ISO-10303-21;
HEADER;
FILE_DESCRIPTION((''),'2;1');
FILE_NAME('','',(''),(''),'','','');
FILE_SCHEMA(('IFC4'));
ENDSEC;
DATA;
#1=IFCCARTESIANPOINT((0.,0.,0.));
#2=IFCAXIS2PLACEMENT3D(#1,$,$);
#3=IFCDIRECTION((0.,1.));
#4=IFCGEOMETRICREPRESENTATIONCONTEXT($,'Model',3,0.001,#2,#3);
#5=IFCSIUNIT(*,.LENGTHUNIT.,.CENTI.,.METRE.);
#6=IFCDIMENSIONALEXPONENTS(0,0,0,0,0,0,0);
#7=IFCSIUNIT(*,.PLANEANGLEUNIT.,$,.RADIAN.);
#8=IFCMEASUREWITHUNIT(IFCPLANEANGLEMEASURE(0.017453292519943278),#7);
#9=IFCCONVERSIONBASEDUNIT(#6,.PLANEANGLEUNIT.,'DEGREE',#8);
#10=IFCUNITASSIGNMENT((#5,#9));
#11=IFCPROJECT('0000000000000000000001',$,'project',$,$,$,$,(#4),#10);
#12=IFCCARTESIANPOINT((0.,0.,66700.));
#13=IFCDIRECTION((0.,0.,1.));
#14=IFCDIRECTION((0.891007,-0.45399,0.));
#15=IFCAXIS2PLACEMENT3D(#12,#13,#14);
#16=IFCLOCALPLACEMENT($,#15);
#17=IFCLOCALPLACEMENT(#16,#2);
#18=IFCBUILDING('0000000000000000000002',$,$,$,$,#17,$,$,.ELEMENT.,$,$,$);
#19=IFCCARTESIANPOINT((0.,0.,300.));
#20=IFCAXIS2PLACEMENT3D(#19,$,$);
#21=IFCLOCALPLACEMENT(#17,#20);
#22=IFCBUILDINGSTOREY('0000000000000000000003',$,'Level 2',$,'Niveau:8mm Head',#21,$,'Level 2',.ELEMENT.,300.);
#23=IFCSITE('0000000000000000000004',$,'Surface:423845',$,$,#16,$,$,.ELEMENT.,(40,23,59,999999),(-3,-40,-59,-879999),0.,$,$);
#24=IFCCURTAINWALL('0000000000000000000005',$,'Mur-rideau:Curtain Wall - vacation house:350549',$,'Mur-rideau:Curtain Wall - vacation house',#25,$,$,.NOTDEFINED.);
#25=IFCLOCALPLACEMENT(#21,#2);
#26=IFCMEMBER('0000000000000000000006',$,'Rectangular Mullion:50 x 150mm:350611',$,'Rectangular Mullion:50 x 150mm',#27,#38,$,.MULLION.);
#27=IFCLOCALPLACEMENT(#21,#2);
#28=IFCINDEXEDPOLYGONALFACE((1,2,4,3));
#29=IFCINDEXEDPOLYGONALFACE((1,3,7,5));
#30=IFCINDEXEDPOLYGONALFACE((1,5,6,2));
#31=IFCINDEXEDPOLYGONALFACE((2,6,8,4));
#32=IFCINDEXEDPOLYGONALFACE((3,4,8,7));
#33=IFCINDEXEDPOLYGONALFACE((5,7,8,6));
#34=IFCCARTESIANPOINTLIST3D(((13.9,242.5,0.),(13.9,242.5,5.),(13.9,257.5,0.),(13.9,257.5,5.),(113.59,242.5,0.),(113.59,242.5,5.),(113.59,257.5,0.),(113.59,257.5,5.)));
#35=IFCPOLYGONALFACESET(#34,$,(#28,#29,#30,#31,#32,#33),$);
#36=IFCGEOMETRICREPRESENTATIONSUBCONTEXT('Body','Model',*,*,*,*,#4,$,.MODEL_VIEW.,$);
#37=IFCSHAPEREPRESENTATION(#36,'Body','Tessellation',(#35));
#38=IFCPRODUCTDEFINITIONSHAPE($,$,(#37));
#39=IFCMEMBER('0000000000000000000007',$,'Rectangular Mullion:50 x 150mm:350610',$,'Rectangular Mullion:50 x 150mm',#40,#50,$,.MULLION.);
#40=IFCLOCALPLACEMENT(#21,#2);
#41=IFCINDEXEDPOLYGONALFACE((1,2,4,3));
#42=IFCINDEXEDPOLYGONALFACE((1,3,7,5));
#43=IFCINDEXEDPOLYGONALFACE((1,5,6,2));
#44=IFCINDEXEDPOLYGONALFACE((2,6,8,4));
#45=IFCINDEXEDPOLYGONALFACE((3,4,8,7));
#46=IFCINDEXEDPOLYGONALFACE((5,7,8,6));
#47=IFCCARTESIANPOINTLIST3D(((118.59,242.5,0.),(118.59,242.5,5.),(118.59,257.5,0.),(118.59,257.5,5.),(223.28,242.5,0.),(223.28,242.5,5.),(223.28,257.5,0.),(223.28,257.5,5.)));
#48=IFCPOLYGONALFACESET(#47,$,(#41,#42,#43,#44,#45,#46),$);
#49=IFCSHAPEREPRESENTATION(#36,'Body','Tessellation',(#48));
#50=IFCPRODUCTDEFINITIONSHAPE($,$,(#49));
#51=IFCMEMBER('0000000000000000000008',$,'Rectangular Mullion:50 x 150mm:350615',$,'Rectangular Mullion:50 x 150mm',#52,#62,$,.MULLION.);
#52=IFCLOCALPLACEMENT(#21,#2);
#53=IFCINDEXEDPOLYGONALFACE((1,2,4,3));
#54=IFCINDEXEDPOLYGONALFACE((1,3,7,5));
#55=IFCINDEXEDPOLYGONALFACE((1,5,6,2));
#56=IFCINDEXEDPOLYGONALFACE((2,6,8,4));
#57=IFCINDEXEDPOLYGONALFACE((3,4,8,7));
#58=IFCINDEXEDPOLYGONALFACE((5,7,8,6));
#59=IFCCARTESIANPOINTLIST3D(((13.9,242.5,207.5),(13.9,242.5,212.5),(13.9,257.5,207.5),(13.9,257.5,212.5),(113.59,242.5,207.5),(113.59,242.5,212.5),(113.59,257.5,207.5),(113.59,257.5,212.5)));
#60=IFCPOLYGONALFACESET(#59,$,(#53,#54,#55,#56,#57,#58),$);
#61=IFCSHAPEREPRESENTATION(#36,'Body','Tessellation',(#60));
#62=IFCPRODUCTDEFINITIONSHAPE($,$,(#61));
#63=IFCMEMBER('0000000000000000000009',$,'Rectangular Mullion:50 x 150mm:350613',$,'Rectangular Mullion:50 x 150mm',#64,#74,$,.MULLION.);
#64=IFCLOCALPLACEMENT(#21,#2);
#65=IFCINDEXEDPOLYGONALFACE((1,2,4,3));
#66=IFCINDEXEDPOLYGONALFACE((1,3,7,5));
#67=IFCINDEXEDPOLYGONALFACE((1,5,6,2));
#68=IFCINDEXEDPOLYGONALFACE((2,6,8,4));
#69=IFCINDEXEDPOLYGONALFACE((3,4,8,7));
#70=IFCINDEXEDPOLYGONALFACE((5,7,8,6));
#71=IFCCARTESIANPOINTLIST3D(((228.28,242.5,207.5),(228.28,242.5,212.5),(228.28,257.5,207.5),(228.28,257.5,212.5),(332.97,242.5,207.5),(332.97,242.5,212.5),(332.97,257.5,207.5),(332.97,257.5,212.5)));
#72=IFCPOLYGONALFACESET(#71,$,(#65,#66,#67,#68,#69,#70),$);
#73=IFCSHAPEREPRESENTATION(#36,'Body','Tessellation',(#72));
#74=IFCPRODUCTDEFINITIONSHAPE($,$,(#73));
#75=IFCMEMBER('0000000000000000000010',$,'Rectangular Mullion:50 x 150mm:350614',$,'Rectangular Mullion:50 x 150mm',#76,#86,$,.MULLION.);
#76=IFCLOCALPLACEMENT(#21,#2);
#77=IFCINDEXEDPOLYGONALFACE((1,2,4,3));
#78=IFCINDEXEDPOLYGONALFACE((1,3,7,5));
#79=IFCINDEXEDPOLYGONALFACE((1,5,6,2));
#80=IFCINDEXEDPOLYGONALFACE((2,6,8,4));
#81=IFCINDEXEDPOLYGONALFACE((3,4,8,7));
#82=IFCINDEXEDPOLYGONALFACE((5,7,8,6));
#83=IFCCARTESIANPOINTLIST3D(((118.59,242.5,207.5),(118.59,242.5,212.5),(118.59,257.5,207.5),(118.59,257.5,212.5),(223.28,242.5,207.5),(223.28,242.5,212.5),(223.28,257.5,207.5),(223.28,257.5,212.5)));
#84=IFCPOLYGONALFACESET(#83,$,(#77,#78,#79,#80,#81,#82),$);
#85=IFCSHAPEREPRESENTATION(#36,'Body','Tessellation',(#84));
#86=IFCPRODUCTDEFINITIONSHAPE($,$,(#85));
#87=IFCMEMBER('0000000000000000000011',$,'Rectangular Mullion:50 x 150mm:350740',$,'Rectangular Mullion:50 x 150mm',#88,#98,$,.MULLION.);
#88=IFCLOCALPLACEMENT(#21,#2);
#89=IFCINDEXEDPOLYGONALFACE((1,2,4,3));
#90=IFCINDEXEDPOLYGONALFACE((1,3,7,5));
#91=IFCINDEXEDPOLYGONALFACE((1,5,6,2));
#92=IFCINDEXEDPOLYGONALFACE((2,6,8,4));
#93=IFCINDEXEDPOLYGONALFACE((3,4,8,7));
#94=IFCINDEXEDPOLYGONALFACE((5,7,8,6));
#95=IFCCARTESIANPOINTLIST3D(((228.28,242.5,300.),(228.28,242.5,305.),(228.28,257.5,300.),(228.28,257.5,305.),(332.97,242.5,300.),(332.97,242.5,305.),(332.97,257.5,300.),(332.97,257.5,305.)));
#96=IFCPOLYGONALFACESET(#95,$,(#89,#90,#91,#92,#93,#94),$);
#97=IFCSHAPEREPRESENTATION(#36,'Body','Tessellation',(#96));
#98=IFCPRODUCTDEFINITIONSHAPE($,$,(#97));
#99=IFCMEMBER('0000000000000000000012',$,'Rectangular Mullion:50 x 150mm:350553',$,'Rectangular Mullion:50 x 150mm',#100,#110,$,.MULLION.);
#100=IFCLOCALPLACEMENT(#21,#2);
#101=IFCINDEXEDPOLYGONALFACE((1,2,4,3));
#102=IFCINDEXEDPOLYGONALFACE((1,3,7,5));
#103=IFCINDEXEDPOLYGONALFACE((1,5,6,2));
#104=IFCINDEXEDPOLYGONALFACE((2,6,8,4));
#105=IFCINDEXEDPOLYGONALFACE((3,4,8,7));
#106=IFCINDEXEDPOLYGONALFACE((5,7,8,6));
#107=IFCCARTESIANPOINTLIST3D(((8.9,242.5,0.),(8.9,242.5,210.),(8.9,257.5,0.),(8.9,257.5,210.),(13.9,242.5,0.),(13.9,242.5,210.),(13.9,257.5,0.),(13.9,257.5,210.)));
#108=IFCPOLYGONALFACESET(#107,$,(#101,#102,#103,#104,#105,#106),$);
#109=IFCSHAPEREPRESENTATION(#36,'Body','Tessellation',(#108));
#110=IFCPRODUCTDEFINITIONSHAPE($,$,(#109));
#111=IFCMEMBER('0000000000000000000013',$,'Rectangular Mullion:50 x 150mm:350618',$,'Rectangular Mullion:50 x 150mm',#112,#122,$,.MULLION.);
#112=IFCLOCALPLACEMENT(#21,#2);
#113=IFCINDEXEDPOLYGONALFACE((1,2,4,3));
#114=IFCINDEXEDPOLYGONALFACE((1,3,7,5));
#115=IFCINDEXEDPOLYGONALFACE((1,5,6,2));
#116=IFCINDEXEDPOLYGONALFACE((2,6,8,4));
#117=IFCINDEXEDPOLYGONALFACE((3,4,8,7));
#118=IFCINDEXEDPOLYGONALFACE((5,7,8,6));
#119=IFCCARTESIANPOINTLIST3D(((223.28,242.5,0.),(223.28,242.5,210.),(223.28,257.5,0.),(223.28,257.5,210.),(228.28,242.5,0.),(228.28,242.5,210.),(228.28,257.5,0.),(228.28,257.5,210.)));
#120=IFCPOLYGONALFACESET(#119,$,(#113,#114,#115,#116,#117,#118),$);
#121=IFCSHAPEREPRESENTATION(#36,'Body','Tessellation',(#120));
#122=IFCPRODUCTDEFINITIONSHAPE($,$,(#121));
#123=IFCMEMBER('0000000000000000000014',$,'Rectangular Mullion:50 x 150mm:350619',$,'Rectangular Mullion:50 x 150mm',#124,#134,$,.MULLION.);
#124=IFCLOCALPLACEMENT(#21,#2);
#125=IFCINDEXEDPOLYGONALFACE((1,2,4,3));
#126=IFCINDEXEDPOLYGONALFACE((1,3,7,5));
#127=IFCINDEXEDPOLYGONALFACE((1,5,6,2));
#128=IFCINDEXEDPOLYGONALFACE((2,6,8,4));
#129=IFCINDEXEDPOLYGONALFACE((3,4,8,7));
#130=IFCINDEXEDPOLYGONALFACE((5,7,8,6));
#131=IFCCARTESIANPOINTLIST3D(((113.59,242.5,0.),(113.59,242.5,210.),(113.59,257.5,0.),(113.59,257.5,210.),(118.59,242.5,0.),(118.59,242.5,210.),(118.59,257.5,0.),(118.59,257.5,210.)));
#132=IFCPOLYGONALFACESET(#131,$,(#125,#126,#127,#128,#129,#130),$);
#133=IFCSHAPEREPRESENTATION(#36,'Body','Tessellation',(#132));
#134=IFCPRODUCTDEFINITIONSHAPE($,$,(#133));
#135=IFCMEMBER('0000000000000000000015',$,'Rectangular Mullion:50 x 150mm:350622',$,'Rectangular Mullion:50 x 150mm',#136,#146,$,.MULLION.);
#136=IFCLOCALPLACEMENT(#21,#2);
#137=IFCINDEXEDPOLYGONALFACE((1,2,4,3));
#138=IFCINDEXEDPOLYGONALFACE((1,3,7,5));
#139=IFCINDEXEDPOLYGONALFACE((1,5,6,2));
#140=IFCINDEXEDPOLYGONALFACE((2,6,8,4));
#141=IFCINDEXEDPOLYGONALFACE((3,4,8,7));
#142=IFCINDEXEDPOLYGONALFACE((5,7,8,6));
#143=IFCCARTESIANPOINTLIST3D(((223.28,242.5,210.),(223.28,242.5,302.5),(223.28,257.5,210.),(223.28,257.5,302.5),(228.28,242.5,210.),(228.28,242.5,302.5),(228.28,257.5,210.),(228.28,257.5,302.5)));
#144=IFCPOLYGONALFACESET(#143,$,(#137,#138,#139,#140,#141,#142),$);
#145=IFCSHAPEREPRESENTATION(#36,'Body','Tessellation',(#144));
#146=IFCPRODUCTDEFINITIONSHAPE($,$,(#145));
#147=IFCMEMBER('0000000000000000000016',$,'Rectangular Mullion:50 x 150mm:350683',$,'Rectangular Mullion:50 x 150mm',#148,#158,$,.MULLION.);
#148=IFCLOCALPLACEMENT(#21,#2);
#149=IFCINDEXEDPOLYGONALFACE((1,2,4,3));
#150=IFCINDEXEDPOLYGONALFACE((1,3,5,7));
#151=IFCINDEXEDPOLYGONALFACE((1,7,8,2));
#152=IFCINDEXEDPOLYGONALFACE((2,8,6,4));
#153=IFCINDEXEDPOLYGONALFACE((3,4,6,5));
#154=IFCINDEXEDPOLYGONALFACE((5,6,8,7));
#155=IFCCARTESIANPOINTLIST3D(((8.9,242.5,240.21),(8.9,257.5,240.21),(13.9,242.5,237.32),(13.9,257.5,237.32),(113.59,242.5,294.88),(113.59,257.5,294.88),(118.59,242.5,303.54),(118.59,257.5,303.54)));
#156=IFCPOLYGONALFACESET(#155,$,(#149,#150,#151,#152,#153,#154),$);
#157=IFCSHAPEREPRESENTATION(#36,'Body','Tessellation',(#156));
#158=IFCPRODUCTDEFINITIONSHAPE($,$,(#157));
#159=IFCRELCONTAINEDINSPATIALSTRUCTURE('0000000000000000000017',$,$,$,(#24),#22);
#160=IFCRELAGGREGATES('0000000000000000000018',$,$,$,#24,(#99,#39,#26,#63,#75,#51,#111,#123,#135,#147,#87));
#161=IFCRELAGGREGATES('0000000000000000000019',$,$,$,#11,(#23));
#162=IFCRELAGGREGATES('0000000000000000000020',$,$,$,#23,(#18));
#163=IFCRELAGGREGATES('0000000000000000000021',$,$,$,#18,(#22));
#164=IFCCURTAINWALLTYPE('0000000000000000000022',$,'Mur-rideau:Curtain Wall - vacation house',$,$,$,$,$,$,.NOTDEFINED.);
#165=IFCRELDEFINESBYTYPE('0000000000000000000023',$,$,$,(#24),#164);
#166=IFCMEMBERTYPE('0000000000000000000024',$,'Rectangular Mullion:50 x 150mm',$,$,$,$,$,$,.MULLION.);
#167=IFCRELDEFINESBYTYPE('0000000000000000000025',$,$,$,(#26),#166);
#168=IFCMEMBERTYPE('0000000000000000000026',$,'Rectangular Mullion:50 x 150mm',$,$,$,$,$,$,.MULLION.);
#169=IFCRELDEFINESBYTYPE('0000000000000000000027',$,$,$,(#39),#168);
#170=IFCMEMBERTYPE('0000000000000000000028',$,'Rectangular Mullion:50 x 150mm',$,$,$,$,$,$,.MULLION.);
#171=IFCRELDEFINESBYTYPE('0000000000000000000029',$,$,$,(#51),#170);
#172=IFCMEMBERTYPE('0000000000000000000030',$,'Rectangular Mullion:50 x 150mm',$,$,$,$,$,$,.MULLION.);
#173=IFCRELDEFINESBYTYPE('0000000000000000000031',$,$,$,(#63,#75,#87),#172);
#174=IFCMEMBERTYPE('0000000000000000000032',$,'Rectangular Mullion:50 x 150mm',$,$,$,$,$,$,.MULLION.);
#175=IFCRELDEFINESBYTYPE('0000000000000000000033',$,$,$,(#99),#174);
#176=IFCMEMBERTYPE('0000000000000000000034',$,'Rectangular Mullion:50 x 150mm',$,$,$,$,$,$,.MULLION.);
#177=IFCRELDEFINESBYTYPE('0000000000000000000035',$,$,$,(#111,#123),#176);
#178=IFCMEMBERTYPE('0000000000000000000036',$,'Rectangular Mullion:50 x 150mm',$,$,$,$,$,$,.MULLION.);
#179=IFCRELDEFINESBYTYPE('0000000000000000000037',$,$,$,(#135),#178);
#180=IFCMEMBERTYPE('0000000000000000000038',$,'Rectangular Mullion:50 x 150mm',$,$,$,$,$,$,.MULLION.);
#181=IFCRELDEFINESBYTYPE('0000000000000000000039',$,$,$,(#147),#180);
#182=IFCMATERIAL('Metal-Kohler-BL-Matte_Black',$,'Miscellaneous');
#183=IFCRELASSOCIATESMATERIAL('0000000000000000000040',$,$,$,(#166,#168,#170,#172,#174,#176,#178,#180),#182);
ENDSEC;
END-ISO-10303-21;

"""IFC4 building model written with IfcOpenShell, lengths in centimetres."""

from ifc_helpers import new_model, entity, si_unit, converted_unit, direction, frame, origin, origin_2d_with_axis, place, context, subcontext, project, spatial, polyline, rectangle, outline, extrude, source, transform, mapped, material, material_profile, profile_set, type_object, type_shapes, element, aggregate, save


model = new_model("IFC4")

# Units and contexts
model_context = context("Model", 3, precision=0.001, world=origin(), true_north=direction((0.0, 1.0)))
body_context = subcontext(model_context, "Body", "Model", "MODEL_VIEW")
ifc_project = project(units=[si_unit("LENGTHUNIT", "METRE", prefix="CENTI"), converted_unit("PLANEANGLEUNIT", "DEGREE", entity("IfcPlaneAngleMeasure", 0.017453292519943278), si_unit("PLANEANGLEUNIT", "RADIAN"), dimensions=[0, 0, 0, 0, 0, 0, 0])], contexts=[model_context])

# Site, building, storey
site_placement = place(None, frame((0.0, 0.0, 66700.0), z_axis=(0.0, 0.0, 1.0), x_axis=(0.891007, -0.45399, 0.0)))
site = spatial("IfcSite", under=ifc_project, at=site_placement, Name="Surface:423845", CompositionType="ELEMENT", RefLatitude=(40, 23, 59, 999999), RefLongitude=(-3, -40, -59, -879999), RefElevation=0.0)
building_placement = place(site_placement, origin())
building = spatial("IfcBuilding", under=site, at=building_placement, CompositionType="ELEMENT")
storey_placement = place(building_placement, frame((0.0, 0.0, 300.0)))
storey = spatial("IfcBuildingStorey", under=building, at=storey_placement, Name="Level 2", ObjectType="Niveau:8mm Head", LongName="Level 2", CompositionType="ELEMENT", Elevation=300.0)

# Curtain wall, members
curtain_wall_type = type_object("IfcCurtainWallType", Name="Mur-rideau:Curtain Wall - vacation house", PredefinedType="NOTDEFINED")
curtain_wall_placement = place(storey_placement, frame((0.0, 0.0, -300.0)))
curtain_wall = element("IfcCurtainWall", 1, at=curtain_wall_placement, inside=storey, type_object=curtain_wall_type, Name="Mur-rideau:Curtain Wall - vacation house:350549", ObjectType="Mur-rideau:Curtain Wall - vacation house", PredefinedType="NOTDEFINED")
ifc_material_1 = material(Name="Metal-Kohler-BL-Matte_Black", Category="Miscellaneous")
ifc_material_profile = material_profile(ifc_material_1, rectangle(XDim=5.0, YDim=15.0, at=origin_2d_with_axis()), Name="50 x 150mm")
ifc_profile_set = profile_set([ifc_material_profile], Name="50 x 150mm")
member_type_1 = type_object("IfcMemberType", Name="Rectangular Mullion:50 x 150mm", PredefinedType="MULLION", material=ifc_profile_set)
shared_shape_1 = source(origin(), body_context, "Body", "SweptSolid", [
    extrude(rectangle(XDim=5.0, YDim=15.0, at=origin_2d_with_axis()), frame((-2.5, 0.0, -99.69), z_axis=(0.0, 0.0, 1.0), x_axis=(-1.0, 0.0, 0.0)), (0.0, 0.0, 1.0), 99.69),
])
type_shapes(member_type_1, [shared_shape_1])
member_1_placement = place(curtain_wall_placement, frame((113.59, 250.0, 300.0), z_axis=(1.0, 0.0, 0.0), x_axis=(0.0, 0.0, -1.0)))
member_1 = element("IfcMember", 2, at=member_1_placement, type_object=member_type_1, Name="Rectangular Mullion:50 x 150mm:350611", ObjectType="Rectangular Mullion:50 x 150mm", PredefinedType="MULLION", context=body_context, shape_type="MappedRepresentation", body=[
    mapped(shared_shape_1, transform((0.0, 0.0, 0.0), scale=1.0)),
])
member_type_2 = type_object("IfcMemberType", Name="Rectangular Mullion:50 x 150mm", PredefinedType="MULLION", material=ifc_profile_set)
shared_shape_2 = source(origin(), body_context, "Body", "SweptSolid", [
    extrude(rectangle(XDim=5.0, YDim=15.0, at=origin_2d_with_axis()), frame((-2.5, 0.0, -104.69), z_axis=(0.0, 0.0, 1.0), x_axis=(-1.0, 0.0, 0.0)), (0.0, 0.0, 1.0), 104.69),
])
type_shapes(member_type_2, [shared_shape_2])
member_2_placement = place(curtain_wall_placement, frame((223.28, 250.0, 300.0), z_axis=(1.0, 0.0, 0.0), x_axis=(0.0, 0.0, -1.0)))
member_2 = element("IfcMember", 3, at=member_2_placement, type_object=member_type_2, Name="Rectangular Mullion:50 x 150mm:350610", ObjectType="Rectangular Mullion:50 x 150mm", PredefinedType="MULLION", context=body_context, shape_type="MappedRepresentation", body=[
    mapped(shared_shape_2, transform((0.0, 0.0, 0.0), scale=1.0)),
])
member_type_3 = type_object("IfcMemberType", Name="Rectangular Mullion:50 x 150mm", PredefinedType="MULLION", material=ifc_profile_set)
shared_shape_3 = source(origin(), body_context, "Body", "SweptSolid", [
    extrude(rectangle(XDim=5.0, YDim=15.0, at=origin_2d_with_axis()), frame((0.0, 0.0, -99.69), z_axis=(0.0, 0.0, 1.0), x_axis=(-1.0, 0.0, 0.0)), (0.0, 0.0, 1.0), 99.69),
])
type_shapes(member_type_3, [shared_shape_3])
member_3_placement = place(curtain_wall_placement, frame((13.9, 250.0, 510.0), z_axis=(-1.0, 0.0, 0.0), x_axis=(0.0, 0.0, 1.0)))
member_3 = element("IfcMember", 4, at=member_3_placement, type_object=member_type_3, Name="Rectangular Mullion:50 x 150mm:350615", ObjectType="Rectangular Mullion:50 x 150mm", PredefinedType="MULLION", context=body_context, shape_type="MappedRepresentation", body=[
    mapped(shared_shape_3, transform((0.0, 0.0, 0.0), scale=1.0)),
])
member_type_4 = type_object("IfcMemberType", Name="Rectangular Mullion:50 x 150mm", PredefinedType="MULLION", material=ifc_profile_set)
shared_shape_4 = source(origin(), body_context, "Body", "SweptSolid", [
    extrude(rectangle(XDim=5.0, YDim=15.0, at=origin_2d_with_axis()), frame((0.0, 0.0, -104.69), z_axis=(0.0, 0.0, 1.0), x_axis=(-1.0, 0.0, 0.0)), (0.0, 0.0, 1.0), 104.69),
])
type_shapes(member_type_4, [shared_shape_4])
member_4_placement = place(curtain_wall_placement, frame((228.28, 250.0, 510.0), z_axis=(-1.0, 0.0, 0.0), x_axis=(0.0, 0.0, 1.0)))
member_4 = element("IfcMember", 5, at=member_4_placement, type_object=member_type_4, Name="Rectangular Mullion:50 x 150mm:350613", ObjectType="Rectangular Mullion:50 x 150mm", PredefinedType="MULLION", context=body_context, shape_type="MappedRepresentation", body=[
    mapped(shared_shape_4, transform((0.0, 0.0, 0.0), scale=1.0)),
])
member_5_placement = place(curtain_wall_placement, frame((118.59, 250.0, 510.0), z_axis=(-1.0, 0.0, 0.0), x_axis=(0.0, 0.0, 1.0)))
member_5 = element("IfcMember", 6, at=member_5_placement, type_object=member_type_4, Name="Rectangular Mullion:50 x 150mm:350614", ObjectType="Rectangular Mullion:50 x 150mm", PredefinedType="MULLION", context=body_context, shape_type="MappedRepresentation", body=[
    mapped(shared_shape_4, transform((0.0, 0.0, 0.0), scale=1.0)),
])
member_6_placement = place(curtain_wall_placement, frame((228.28, 250.0, 602.5), z_axis=(-1.0, 0.0, 0.0), x_axis=(0.0, 0.0, 1.0)))
member_6 = element("IfcMember", 7, at=member_6_placement, type_object=member_type_4, Name="Rectangular Mullion:50 x 150mm:350740", ObjectType="Rectangular Mullion:50 x 150mm", PredefinedType="MULLION", context=body_context, shape_type="MappedRepresentation", body=[
    mapped(shared_shape_4, transform((0.0, 0.0, 0.0), scale=1.0)),
])
member_type_5 = type_object("IfcMemberType", Name="Rectangular Mullion:50 x 150mm", PredefinedType="MULLION", material=ifc_profile_set)
shared_shape_5 = source(origin(), body_context, "Body", "SweptSolid", [
    extrude(rectangle(XDim=5.0, YDim=15.0, at=origin_2d_with_axis()), frame((-2.5, 0.0, -210.0), z_axis=(0.0, 0.0, 1.0), x_axis=(-1.0, 0.0, 0.0)), (0.0, 0.0, 1.0), 210.0),
])
type_shapes(member_type_5, [shared_shape_5])
member_7_placement = place(curtain_wall_placement, frame((8.9, 250.0, 300.0), z_axis=(0.0, 0.0, -1.0), x_axis=(-1.0, 0.0, 0.0)))
member_7 = element("IfcMember", 8, at=member_7_placement, type_object=member_type_5, Name="Rectangular Mullion:50 x 150mm:350553", ObjectType="Rectangular Mullion:50 x 150mm", PredefinedType="MULLION", context=body_context, shape_type="MappedRepresentation", body=[
    mapped(shared_shape_5, transform((0.0, 0.0, 0.0), scale=1.0)),
])
member_type_6 = type_object("IfcMemberType", Name="Rectangular Mullion:50 x 150mm", PredefinedType="MULLION", material=ifc_profile_set)
shared_shape_6 = source(origin(), body_context, "Body", "SweptSolid", [
    extrude(rectangle(XDim=5.0, YDim=15.0, at=origin_2d_with_axis()), frame((0.0, 0.0, -210.0), z_axis=(0.0, 0.0, 1.0), x_axis=(-1.0, 0.0, 0.0)), (0.0, 0.0, 1.0), 210.0),
])
type_shapes(member_type_6, [shared_shape_6])
member_8_placement = place(curtain_wall_placement, frame((225.78, 250.0, 300.0), z_axis=(0.0, 0.0, -1.0), x_axis=(-1.0, 0.0, 0.0)))
member_8 = element("IfcMember", 9, at=member_8_placement, type_object=member_type_6, Name="Rectangular Mullion:50 x 150mm:350618", ObjectType="Rectangular Mullion:50 x 150mm", PredefinedType="MULLION", context=body_context, shape_type="MappedRepresentation", body=[
    mapped(shared_shape_6, transform((0.0, 0.0, 0.0), scale=1.0)),
])
member_9_placement = place(curtain_wall_placement, frame((116.09, 250.0, 300.0), z_axis=(0.0, 0.0, -1.0), x_axis=(-1.0, 0.0, 0.0)))
member_9 = element("IfcMember", 10, at=member_9_placement, type_object=member_type_6, Name="Rectangular Mullion:50 x 150mm:350619", ObjectType="Rectangular Mullion:50 x 150mm", PredefinedType="MULLION", context=body_context, shape_type="MappedRepresentation", body=[
    mapped(shared_shape_6, transform((0.0, 0.0, 0.0), scale=1.0)),
])
member_type_7 = type_object("IfcMemberType", Name="Rectangular Mullion:50 x 150mm", PredefinedType="MULLION", material=ifc_profile_set)
shared_shape_7 = source(origin(), body_context, "Body", "SweptSolid", [
    extrude(rectangle(XDim=5.0, YDim=15.0, at=origin_2d_with_axis()), frame((0.0, 0.0, -92.5), z_axis=(0.0, 0.0, 1.0), x_axis=(-1.0, 0.0, 0.0)), (0.0, 0.0, 1.0), 92.5),
])
type_shapes(member_type_7, [shared_shape_7])
member_10_placement = place(curtain_wall_placement, frame((225.78, 250.0, 510.0), z_axis=(0.0, 0.0, -1.0), x_axis=(-1.0, 0.0, 0.0)))
member_10 = element("IfcMember", 11, at=member_10_placement, type_object=member_type_7, Name="Rectangular Mullion:50 x 150mm:350622", ObjectType="Rectangular Mullion:50 x 150mm", PredefinedType="MULLION", context=body_context, shape_type="MappedRepresentation", body=[
    mapped(shared_shape_7, transform((0.0, 0.0, 0.0), scale=1.0)),
])
member_type_8 = type_object("IfcMemberType", Name="Rectangular Mullion:50 x 150mm", PredefinedType="MULLION", material=ifc_profile_set)
shared_shape_8 = source(origin(), body_context, "Body", "SweptSolid", [
    extrude(outline(polyline([(-61.89, -2.5), (64.77, -2.5), (56.11, 2.5), (-59.0, 2.5), (-61.89, -2.5)])), frame((-2.5, -7.5, -61.89), z_axis=(0.0, 1.0, 0.0), x_axis=(0.0, 0.0, -1.0)), (0.0, 0.0, 1.0), 15.0),
])
type_shapes(member_type_8, [shared_shape_8])
member_11_placement = place(curtain_wall_placement, frame((8.9, 250.0, 540.21), z_axis=(-0.866025, 0.0, -0.5), x_axis=(-0.5, 0.0, 0.866025)))
member_11 = element("IfcMember", 12, at=member_11_placement, type_object=member_type_8, Name="Rectangular Mullion:50 x 150mm:350683", ObjectType="Rectangular Mullion:50 x 150mm", PredefinedType="MULLION", context=body_context, shape_type="MappedRepresentation", body=[
    mapped(shared_shape_8, transform((0.0, 0.0, 0.0), scale=1.0)),
])
aggregate(curtain_wall, [member_7, member_2, member_1, member_4, member_5, member_3, member_8, member_9, member_10, member_11, member_6])

save(model, "model.ifc")
